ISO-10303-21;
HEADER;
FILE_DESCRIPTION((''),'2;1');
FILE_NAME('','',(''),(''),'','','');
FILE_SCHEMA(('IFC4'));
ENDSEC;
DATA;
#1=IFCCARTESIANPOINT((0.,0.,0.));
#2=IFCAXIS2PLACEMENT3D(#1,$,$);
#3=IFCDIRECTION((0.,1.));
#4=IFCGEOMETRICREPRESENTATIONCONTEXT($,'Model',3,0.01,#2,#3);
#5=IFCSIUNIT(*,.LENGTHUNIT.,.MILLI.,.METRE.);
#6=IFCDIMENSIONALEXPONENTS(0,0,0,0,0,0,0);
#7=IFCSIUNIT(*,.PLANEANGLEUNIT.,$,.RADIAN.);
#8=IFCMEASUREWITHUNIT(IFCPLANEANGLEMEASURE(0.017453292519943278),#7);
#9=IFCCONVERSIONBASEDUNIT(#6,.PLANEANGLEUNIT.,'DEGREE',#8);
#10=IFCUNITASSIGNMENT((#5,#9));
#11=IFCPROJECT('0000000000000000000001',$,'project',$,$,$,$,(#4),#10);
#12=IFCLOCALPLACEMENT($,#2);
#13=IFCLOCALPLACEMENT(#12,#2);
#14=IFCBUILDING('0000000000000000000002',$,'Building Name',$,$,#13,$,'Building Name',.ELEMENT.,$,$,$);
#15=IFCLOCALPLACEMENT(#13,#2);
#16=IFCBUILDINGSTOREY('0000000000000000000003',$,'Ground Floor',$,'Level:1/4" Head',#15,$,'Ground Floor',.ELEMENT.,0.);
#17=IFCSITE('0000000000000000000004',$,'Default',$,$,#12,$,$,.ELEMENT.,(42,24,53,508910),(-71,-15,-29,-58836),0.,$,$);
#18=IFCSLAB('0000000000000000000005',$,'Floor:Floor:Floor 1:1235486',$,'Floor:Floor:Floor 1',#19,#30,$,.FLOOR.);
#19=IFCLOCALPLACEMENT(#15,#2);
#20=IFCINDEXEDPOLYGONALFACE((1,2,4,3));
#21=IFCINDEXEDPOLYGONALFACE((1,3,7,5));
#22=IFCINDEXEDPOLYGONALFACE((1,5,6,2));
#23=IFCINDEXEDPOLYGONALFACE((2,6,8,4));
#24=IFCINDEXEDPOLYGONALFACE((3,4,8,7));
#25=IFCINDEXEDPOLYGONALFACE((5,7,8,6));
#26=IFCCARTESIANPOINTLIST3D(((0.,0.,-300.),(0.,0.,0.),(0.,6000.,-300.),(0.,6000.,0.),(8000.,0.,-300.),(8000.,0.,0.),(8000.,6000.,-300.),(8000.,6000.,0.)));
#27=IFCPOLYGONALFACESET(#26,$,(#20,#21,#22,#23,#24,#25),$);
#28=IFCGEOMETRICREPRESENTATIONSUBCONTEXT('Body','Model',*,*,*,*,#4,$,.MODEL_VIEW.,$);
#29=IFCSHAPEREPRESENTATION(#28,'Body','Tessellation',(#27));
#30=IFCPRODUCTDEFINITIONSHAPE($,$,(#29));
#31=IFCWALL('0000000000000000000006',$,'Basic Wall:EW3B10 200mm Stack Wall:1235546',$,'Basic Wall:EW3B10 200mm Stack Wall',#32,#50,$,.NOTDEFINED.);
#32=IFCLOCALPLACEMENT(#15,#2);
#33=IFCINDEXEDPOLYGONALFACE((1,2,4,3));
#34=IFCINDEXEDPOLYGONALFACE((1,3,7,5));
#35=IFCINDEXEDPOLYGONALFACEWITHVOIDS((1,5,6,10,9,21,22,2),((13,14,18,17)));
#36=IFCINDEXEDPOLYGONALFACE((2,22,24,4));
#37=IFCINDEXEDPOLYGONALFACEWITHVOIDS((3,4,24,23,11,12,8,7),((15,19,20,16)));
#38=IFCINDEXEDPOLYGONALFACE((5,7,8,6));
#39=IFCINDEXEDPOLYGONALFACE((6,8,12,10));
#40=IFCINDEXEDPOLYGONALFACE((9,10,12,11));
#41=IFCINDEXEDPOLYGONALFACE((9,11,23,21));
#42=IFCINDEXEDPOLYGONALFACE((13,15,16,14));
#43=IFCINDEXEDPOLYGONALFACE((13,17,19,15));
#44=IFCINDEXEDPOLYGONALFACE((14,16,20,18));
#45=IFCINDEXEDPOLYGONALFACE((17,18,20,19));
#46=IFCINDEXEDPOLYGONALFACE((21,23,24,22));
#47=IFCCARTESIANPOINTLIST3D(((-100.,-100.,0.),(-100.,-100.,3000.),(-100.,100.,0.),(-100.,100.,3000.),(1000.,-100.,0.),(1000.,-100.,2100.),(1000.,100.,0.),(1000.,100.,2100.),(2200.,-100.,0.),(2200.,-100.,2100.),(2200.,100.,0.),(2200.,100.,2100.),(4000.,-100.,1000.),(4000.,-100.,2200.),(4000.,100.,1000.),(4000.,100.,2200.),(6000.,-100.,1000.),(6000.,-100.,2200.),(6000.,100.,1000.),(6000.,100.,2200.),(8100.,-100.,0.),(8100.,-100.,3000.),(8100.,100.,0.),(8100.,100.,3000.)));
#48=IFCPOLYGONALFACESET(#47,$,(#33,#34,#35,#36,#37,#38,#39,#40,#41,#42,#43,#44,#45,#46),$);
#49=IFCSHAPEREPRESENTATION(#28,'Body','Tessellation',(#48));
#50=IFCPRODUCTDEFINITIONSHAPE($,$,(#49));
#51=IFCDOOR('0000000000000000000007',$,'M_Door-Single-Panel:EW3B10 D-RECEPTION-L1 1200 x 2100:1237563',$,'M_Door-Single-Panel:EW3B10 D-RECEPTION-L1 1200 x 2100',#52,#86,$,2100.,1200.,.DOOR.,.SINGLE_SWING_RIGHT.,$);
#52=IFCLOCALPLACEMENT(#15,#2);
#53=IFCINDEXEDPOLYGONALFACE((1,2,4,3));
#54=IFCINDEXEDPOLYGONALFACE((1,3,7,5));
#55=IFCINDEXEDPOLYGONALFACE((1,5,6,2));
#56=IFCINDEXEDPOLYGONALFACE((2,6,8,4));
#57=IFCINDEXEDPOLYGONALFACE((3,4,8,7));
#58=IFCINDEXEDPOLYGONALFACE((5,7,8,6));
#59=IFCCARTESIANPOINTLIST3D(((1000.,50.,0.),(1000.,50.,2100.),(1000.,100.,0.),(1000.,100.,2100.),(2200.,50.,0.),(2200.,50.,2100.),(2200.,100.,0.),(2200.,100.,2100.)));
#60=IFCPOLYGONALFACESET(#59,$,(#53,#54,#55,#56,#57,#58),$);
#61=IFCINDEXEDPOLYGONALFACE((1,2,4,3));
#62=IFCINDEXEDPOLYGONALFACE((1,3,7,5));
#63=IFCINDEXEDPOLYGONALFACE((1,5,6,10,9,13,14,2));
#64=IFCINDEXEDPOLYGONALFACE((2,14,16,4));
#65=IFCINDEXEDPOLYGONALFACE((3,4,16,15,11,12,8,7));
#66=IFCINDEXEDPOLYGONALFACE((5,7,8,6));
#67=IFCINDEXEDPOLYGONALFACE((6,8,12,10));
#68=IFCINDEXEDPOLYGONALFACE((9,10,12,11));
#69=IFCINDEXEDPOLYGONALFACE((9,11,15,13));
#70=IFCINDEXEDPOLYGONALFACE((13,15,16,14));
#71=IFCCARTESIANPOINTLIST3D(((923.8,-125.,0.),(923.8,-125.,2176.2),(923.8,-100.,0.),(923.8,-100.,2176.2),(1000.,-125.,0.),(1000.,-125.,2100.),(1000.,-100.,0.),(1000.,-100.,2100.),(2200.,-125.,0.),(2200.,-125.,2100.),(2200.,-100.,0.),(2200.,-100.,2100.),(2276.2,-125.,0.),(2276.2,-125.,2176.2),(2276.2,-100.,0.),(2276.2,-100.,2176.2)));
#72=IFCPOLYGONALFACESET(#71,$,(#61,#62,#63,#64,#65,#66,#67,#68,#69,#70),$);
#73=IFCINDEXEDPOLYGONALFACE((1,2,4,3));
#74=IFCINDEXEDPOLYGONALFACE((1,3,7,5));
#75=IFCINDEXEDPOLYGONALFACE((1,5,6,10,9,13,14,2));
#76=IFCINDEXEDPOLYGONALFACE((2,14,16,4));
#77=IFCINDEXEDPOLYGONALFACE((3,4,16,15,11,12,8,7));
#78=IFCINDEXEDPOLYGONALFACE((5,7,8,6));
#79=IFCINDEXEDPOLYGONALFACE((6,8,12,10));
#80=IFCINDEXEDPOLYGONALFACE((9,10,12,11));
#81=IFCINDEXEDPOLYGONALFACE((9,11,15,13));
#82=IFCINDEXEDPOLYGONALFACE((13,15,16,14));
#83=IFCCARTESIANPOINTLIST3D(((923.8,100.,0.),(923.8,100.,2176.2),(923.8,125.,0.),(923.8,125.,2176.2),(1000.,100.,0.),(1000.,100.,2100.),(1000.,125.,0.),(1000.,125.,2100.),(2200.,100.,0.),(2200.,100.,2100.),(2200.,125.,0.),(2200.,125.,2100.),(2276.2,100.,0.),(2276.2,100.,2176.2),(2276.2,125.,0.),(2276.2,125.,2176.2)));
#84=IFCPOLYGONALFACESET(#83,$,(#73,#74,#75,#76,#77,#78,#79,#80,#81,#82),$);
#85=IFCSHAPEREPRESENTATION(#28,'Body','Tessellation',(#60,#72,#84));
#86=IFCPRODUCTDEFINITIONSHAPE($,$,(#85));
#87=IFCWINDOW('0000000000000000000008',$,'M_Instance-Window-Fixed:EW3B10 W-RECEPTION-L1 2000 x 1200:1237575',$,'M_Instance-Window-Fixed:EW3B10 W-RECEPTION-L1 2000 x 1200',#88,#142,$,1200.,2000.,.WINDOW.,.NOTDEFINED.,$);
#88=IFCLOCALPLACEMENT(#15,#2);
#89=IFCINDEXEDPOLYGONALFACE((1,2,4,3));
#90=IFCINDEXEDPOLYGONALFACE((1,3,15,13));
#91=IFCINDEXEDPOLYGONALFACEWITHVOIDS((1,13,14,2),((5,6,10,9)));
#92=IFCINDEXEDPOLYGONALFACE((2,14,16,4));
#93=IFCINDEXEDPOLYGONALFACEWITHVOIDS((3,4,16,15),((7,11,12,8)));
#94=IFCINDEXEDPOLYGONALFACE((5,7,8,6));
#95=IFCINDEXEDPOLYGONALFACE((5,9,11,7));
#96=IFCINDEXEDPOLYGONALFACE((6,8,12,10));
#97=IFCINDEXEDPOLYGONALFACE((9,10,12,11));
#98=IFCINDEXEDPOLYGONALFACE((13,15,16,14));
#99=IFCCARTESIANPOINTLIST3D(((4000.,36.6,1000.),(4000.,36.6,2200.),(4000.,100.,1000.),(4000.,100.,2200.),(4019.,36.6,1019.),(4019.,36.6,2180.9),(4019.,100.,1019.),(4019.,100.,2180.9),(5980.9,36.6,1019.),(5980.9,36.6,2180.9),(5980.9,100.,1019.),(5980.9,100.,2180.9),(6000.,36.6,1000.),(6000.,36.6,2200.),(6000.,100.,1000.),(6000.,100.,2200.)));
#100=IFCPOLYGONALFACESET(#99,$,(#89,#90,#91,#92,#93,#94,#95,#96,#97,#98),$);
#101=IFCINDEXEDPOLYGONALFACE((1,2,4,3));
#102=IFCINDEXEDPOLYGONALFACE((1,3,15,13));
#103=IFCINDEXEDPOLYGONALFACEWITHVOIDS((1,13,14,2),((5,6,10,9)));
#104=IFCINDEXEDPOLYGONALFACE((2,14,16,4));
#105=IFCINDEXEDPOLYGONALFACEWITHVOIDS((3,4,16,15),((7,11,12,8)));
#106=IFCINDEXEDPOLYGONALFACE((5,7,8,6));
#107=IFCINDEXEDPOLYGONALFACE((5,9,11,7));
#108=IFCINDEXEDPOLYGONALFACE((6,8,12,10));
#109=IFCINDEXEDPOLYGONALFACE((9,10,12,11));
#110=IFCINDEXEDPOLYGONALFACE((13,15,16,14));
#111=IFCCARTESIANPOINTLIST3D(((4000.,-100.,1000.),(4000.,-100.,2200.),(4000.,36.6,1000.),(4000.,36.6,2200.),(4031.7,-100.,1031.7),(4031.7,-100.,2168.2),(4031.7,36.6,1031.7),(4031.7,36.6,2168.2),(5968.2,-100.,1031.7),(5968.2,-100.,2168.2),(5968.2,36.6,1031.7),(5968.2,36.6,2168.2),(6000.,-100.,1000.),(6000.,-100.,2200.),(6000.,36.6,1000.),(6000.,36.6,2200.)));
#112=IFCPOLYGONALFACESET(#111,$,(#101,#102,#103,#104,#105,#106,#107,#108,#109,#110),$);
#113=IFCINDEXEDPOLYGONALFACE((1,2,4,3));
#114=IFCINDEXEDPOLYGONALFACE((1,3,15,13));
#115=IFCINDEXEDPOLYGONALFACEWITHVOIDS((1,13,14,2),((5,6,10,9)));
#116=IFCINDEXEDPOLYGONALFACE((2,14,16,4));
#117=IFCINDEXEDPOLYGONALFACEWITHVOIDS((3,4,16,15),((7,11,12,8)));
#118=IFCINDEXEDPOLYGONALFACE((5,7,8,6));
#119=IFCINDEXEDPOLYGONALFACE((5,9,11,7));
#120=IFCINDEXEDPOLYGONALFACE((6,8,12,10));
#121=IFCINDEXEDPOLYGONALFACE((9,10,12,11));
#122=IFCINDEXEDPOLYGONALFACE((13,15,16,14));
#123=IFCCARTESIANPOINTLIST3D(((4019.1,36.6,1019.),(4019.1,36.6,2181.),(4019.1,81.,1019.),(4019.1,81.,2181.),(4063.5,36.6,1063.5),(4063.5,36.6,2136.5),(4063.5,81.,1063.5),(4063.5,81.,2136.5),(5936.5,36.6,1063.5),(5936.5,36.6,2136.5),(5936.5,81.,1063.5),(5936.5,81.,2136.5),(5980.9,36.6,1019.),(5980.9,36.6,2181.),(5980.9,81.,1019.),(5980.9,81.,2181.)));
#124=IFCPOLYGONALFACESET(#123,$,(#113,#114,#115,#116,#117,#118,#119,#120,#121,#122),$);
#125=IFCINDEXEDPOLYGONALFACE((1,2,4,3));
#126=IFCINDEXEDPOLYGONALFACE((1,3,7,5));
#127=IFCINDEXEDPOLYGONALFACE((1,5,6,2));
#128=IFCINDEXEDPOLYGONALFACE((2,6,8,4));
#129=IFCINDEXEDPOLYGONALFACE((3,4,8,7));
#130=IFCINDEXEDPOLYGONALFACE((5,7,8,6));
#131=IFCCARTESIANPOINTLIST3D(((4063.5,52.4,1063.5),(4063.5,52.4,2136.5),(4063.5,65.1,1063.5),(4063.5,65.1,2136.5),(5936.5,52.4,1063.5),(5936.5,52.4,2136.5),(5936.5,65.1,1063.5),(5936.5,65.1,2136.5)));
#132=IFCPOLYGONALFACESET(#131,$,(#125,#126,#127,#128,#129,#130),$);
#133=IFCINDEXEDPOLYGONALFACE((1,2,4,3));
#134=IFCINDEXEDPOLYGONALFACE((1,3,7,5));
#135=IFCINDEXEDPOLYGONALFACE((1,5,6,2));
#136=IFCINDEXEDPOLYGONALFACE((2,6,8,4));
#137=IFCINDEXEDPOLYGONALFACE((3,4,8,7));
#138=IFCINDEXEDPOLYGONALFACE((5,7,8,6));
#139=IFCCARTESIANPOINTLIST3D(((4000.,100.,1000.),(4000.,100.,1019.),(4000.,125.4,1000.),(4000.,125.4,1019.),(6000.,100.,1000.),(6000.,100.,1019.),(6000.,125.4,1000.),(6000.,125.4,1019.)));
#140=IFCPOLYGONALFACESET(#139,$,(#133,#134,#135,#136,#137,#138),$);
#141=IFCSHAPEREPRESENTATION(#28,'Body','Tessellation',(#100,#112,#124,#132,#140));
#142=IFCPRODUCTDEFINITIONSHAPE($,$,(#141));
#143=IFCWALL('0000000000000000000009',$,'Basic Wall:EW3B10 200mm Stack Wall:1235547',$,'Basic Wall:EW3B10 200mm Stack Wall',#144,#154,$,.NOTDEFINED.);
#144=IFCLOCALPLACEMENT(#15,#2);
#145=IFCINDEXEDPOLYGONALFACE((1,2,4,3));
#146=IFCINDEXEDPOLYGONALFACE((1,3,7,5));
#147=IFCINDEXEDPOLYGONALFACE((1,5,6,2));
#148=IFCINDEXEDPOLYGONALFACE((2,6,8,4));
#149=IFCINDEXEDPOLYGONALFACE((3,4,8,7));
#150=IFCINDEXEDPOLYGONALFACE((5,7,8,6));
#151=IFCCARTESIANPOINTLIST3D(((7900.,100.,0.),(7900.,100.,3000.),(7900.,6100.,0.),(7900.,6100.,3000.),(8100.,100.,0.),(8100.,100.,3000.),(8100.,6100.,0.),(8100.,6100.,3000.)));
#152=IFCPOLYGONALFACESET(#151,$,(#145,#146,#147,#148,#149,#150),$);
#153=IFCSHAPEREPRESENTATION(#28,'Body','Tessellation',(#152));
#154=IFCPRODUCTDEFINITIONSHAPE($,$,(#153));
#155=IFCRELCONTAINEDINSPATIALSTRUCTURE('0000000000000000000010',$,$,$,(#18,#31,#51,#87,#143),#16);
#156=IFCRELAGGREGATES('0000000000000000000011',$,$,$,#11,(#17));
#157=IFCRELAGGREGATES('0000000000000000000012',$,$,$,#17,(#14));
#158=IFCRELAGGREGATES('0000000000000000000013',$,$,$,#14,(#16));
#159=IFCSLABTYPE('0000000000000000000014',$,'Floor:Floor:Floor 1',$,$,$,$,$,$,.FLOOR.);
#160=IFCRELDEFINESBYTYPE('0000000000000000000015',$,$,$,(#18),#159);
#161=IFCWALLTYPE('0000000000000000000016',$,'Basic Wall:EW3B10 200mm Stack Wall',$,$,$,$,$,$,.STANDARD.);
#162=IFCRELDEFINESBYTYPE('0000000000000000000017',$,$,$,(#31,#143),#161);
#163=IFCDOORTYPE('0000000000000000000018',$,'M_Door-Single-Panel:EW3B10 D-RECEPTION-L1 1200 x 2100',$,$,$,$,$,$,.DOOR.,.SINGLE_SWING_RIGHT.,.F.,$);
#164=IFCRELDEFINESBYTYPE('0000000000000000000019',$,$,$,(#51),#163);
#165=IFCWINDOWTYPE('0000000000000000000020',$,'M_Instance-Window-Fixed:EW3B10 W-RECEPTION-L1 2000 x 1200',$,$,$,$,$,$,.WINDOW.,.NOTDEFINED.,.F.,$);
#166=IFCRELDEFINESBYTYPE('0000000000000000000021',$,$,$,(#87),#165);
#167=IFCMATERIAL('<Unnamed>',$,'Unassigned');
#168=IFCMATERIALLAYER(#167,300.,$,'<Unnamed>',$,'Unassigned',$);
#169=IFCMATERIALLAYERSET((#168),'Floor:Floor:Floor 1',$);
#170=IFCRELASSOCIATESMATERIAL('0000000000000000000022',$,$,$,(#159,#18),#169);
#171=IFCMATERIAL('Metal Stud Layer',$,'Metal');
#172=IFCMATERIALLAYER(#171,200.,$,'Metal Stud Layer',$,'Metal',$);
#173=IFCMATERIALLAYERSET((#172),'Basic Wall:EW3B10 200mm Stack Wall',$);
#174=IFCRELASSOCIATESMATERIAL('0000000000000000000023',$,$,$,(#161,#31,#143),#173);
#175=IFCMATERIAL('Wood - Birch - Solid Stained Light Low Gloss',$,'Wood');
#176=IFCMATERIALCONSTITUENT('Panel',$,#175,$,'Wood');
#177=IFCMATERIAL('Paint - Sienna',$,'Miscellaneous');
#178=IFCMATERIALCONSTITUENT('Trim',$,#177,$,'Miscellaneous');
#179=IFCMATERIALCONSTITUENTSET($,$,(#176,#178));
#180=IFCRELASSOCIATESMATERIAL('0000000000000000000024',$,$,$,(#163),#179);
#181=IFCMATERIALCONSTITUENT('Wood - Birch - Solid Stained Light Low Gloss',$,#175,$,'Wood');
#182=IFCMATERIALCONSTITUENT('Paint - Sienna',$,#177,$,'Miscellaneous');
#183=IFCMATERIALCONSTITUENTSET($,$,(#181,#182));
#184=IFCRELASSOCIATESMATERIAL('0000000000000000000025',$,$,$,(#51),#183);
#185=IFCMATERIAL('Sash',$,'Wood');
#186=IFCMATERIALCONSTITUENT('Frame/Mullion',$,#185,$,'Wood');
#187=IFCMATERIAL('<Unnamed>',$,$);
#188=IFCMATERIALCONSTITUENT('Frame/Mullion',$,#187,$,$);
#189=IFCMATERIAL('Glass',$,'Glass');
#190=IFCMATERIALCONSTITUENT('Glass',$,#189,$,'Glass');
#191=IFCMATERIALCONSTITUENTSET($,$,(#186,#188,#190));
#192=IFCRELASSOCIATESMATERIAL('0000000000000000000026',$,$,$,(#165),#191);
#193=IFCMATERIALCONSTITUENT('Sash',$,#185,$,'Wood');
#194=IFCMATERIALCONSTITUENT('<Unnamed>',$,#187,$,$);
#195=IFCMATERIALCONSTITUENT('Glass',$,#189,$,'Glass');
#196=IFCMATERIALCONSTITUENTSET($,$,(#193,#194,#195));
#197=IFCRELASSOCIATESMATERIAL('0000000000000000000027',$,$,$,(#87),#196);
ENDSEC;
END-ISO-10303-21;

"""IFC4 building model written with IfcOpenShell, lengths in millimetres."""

from ifc_helpers import new_model, entity, si_unit, converted_unit, direction, frame, frame_2d, origin, origin_2d_with_axis, place, context, subcontext, project, spatial, polyline, rectangle, outline, extrude, source, transform, mapped, material, layer, layer_set, layer_usage, constituent, constituent_set, type_object, type_shapes, element, fill, save


model = new_model("IFC4")

# Units and contexts
model_context = context("Model", 3, precision=0.01, world=origin(), true_north=direction((0.0, 1.0)))
body_context = subcontext(model_context, "Body", "Model", "MODEL_VIEW")
ifc_project = project(units=[si_unit("LENGTHUNIT", "METRE", prefix="MILLI"), converted_unit("PLANEANGLEUNIT", "DEGREE", entity("IfcPlaneAngleMeasure", 0.017453292519943278), si_unit("PLANEANGLEUNIT", "RADIAN"), dimensions=[0, 0, 0, 0, 0, 0, 0])], contexts=[model_context])

# Site, building, storey
site_placement = place(None, origin())
site = spatial("IfcSite", under=ifc_project, at=site_placement, Name="Default", CompositionType="ELEMENT", RefLatitude=(42, 24, 53, 508910), RefLongitude=(-71, -15, -29, -58836), RefElevation=0.0)
building_placement = place(site_placement, origin())
building = spatial("IfcBuilding", under=site, at=building_placement, Name="Building Name", LongName="Building Name", CompositionType="ELEMENT")
storey_placement = place(building_placement, origin())
storey = spatial("IfcBuildingStorey", under=building, at=storey_placement, Name="Ground Floor", ObjectType="Level:1/4\" Head", LongName="Ground Floor", CompositionType="ELEMENT", Elevation=0.0)

# Slab
ifc_material_1 = material(Name="<Unnamed>", Category="Unassigned")
ifc_layer_1 = layer(ifc_material_1, 300.0, Name="<Unnamed>", Category="Unassigned")
ifc_layer_set_1 = layer_set([ifc_layer_1], Name="Floor:Floor:Floor 1")
ifc_layer_usage_1 = layer_usage(ifc_layer_set_1, "AXIS3", "POSITIVE", 0.0)
slab_type = type_object("IfcSlabType", Name="Floor:Floor:Floor 1", PredefinedType="FLOOR", material=ifc_layer_set_1)
slab_placement = place(storey_placement, origin())
element("IfcSlab", 1, at=slab_placement, inside=storey, type_object=slab_type, material=ifc_layer_usage_1, Name="Floor:Floor:Floor 1:1235486", ObjectType="Floor:Floor:Floor 1", PredefinedType="FLOOR", context=body_context, shape_type="SweptSolid", body=[
    extrude(rectangle(XDim=6000.0, YDim=8000.0, at=origin_2d_with_axis()), frame((4000.0, 3000.0, 0.0), z_axis=(0.0, 0.0, -1.0), x_axis=(0.0, 1.0, 0.0)), (0.0, 0.0, 1.0), 300.0),
])

# Wall, openings, door, window
ifc_material_2 = material(Name="Metal Stud Layer", Category="Metal")
ifc_layer_2 = layer(ifc_material_2, 200.0, Name="Metal Stud Layer", Category="Metal")
ifc_layer_set_2 = layer_set([ifc_layer_2], Name="Basic Wall:EW3B10 200mm Stack Wall")
ifc_layer_usage_2 = layer_usage(ifc_layer_set_2, "AXIS2", "NEGATIVE", 100.0)
wall_type = type_object("IfcWallType", Name="Basic Wall:EW3B10 200mm Stack Wall", PredefinedType="STANDARD", material=ifc_layer_set_2)
wall_1_placement = place(storey_placement, frame((-100.0, 0.0, 0.0)))
wall_1 = element("IfcWall", 2, at=wall_1_placement, inside=storey, type_object=wall_type, material=ifc_layer_usage_2, Name="Basic Wall:EW3B10 200mm Stack Wall:1235546", ObjectType="Basic Wall:EW3B10 200mm Stack Wall", PredefinedType="NOTDEFINED", context=body_context, shape_type="SweptSolid", body=[
    extrude(rectangle(XDim=8200.0, YDim=200.0, at=frame_2d((4100.0, 0.0), x_axis=(1.0, 0.0))), origin(), (0.0, 0.0, 1.0), 3000.0),
])
opening_1_placement = place(wall_1_placement, frame((1100.0, -100.0, 0.0)))
opening_1 = element("IfcOpeningElement", 3, at=opening_1_placement, cuts=wall_1, PredefinedType="OPENING", context=body_context, shape_type="SweptSolid", body=[
    extrude(rectangle(XDim=1200.0, YDim=2100.0, at=frame_2d((1050.0, 600.0), x_axis=(0.0, 1.0))), frame((0.0, 0.0, 0.0), z_axis=(0.0, 1.0, 0.0), x_axis=(0.0, 0.0, 1.0)), (0.0, 0.0, 1.0), 200.0),
])
opening_2_placement = place(wall_1_placement, frame((4100.0, -100.0, 1000.0)))
opening_2 = element("IfcOpeningElement", 4, at=opening_2_placement, cuts=wall_1, PredefinedType="OPENING", context=body_context, shape_type="SweptSolid", body=[
    extrude(rectangle(XDim=1200.0, YDim=2000.0, at=frame_2d((600.0, 1000.0), x_axis=(-1.0, 0.0))), frame((0.0, 0.0, 0.0), z_axis=(0.0, 1.0, 0.0), x_axis=(0.0, 0.0, 1.0)), (0.0, 0.0, 1.0), 200.0),
])
ifc_material_3 = material(Name="Wood - Birch - Solid Stained Light Low Gloss", Category="Wood")
ifc_constituent_1 = constituent(ifc_material_3, Name="Wood - Birch - Solid Stained Light Low Gloss", Category="Wood")
ifc_material_4 = material(Name="Paint - Sienna", Category="Miscellaneous")
ifc_constituent_2 = constituent(ifc_material_4, Name="Paint - Sienna", Category="Miscellaneous")
ifc_constituent_set_1 = constituent_set(constituents=[ifc_constituent_1, ifc_constituent_2])
ifc_constituent_3 = constituent(ifc_material_3, Name="Panel", Category="Wood")
ifc_constituent_4 = constituent(ifc_material_4, Name="Trim", Category="Miscellaneous")
ifc_constituent_set_2 = constituent_set(constituents=[ifc_constituent_3, ifc_constituent_4])
door_type = type_object("IfcDoorType", Name="M_Door-Single-Panel:EW3B10 D-RECEPTION-L1 1200 x 2100", OperationType="SINGLE_SWING_RIGHT", ParameterTakesPrecedence=False, PredefinedType="DOOR", material=ifc_constituent_set_2)
shared_shape_1 = source(origin(), body_context, "Body", "SweptSolid", [
    extrude(rectangle(XDim=50.0, YDim=1200.0, at=frame_2d((0.0, 0.0), x_axis=(1.0, 0.0))), frame((600.0, 175.0, 0.0), z_axis=(0.0, 0.0, 1.0), x_axis=(0.0, 1.0, 0.0)), (0.0, 0.0, 1.0), 2100.0),
    extrude(outline(polyline([(-1107.1, -676.2), (1069.0, -676.2), (1069.0, -600.0), (-1030.9, -600.0), (-1030.9, 600.0), (1069.0, 600.0), (1069.0, 676.2), (-1107.1, 676.2), (-1107.1, -676.2)])), frame((600.0, -25.0, 1069.0), z_axis=(0.0, 1.0, 0.0), x_axis=(0.0, 0.0, -1.0)), (0.0, 0.0, 1.0), 25.0),
    extrude(outline(polyline([(-676.2, -1107.1), (676.2, -1107.1), (676.2, 1069.1), (600.0, 1069.1), (600.0, -1031.0), (-600.0, -1031.0), (-600.0, 1069.1), (-676.2, 1069.1), (-676.2, -1107.1)])), frame((600.0, 200.0, 1069.1), z_axis=(0.0, 1.0, 0.0), x_axis=(1.0, 0.0, 0.0)), (0.0, 0.0, 1.0), 25.0),
])
type_shapes(door_type, [shared_shape_1])
door_placement = place(opening_1_placement, origin())
door = element("IfcDoor", 5, at=door_placement, inside=storey, type_object=door_type, material=ifc_constituent_set_1, Name="M_Door-Single-Panel:EW3B10 D-RECEPTION-L1 1200 x 2100:1237563", ObjectType="M_Door-Single-Panel:EW3B10 D-RECEPTION-L1 1200 x 2100", OperationType="SINGLE_SWING_RIGHT", OverallHeight=2100.0, OverallWidth=1200.0, PredefinedType="DOOR", context=body_context, shape_type="MappedRepresentation", body=[
    mapped(shared_shape_1, transform((0.0, 0.0, 0.0), scale=1.0)),
])
fill(opening_1, door)
ifc_material_5 = material(Name="Sash", Category="Wood")
ifc_constituent_5 = constituent(ifc_material_5, Name="Sash", Category="Wood")
ifc_material_6 = material(Name="<Unnamed>")
ifc_constituent_6 = constituent(ifc_material_6, Name="<Unnamed>")
ifc_material_7 = material(Name="Glass", Category="Glass")
ifc_constituent_7 = constituent(ifc_material_7, Name="Glass", Category="Glass")
ifc_constituent_set_3 = constituent_set(constituents=[ifc_constituent_5, ifc_constituent_6, ifc_constituent_7])
ifc_constituent_8 = constituent(ifc_material_5, Name="Frame/Mullion", Category="Wood")
ifc_constituent_9 = constituent(ifc_material_6, Name="Frame/Mullion")
ifc_constituent_10 = constituent(ifc_material_7, Name="Glass", Category="Glass")
ifc_constituent_set_4 = constituent_set(constituents=[ifc_constituent_8, ifc_constituent_9, ifc_constituent_10])
window_type = type_object("IfcWindowType", Name="M_Instance-Window-Fixed:EW3B10 W-RECEPTION-L1 2000 x 1200", ParameterTakesPrecedence=False, PartitioningType="NOTDEFINED", PredefinedType="WINDOW", material=ifc_constituent_set_4)
shared_shape_2 = source(origin(), body_context, "Body", "SweptSolid", [
    extrude(outline(polyline([(-600.0, -1000.0), (600.0, -1000.0), (600.0, 1000.0), (-600.0, 1000.0), (-600.0, -1000.0)]), holes=[polyline([(-580.9, -980.9), (-580.9, 981.0), (581.0, 981.0), (581.0, -980.9), (-580.9, -980.9)])]), frame((1000.0, 136.6, 600.0), z_axis=(0.0, 1.0, 0.0), x_axis=(0.0, 0.0, -1.0)), (0.0, 0.0, 1.0), 63.5),
    extrude(outline(polyline([(-1000.0, -600.0), (1000.0, -600.0), (1000.0, 600.0), (-1000.0, 600.0), (-1000.0, -600.0)]), holes=[polyline([(-968.3, -568.2), (-968.3, 568.3), (968.2, 568.3), (968.2, -568.2), (-968.3, -568.2)])]), frame((1000.0, 0.0, 600.0), z_axis=(0.0, 1.0, 0.0), x_axis=(1.0, 0.0, 0.0)), (0.0, 0.0, 1.0), 136.6),
    extrude(outline(polyline([(-980.9, -581.0), (980.9, -581.0), (980.9, 581.0), (-980.9, 581.0), (-980.9, -581.0)]), holes=[polyline([(-936.5, -536.5), (-936.5, 536.5), (936.5, 536.5), (936.5, -536.5), (-936.5, -536.5)])]), frame((1000.0, 136.6, 600.0), z_axis=(0.0, 1.0, 0.0), x_axis=(1.0, 0.0, 0.0)), (0.0, 0.0, 1.0), 44.4),
    extrude(rectangle(XDim=12.7, YDim=1873.0, at=frame_2d((0.0, 0.0), x_axis=(1.0, 0.0))), frame((1000.0, 158.8, 63.5), z_axis=(0.0, 0.0, 1.0), x_axis=(0.0, 1.0, 0.0)), (0.0, 0.0, 1.0), 1073.0),
    extrude(rectangle(XDim=25.4, YDim=2000.0, at=frame_2d((0.0, 0.0), x_axis=(1.0, 0.0))), frame((1000.0, 212.7, 0.0), z_axis=(0.0, 0.0, 1.0), x_axis=(0.0, -1.0, 0.0)), (0.0, 0.0, 1.0), 19.0),
])
type_shapes(window_type, [shared_shape_2])
window_placement = place(opening_2_placement, origin())
window = element("IfcWindow", 6, at=window_placement, inside=storey, type_object=window_type, material=ifc_constituent_set_3, Name="M_Instance-Window-Fixed:EW3B10 W-RECEPTION-L1 2000 x 1200:1237575", ObjectType="M_Instance-Window-Fixed:EW3B10 W-RECEPTION-L1 2000 x 1200", OverallHeight=1200.0, OverallWidth=2000.0, PartitioningType="NOTDEFINED", PredefinedType="WINDOW", context=body_context, shape_type="MappedRepresentation", body=[
    mapped(shared_shape_2, transform((0.0, 0.0, 0.0), scale=1.0)),
])
fill(opening_2, window)

# Wall
ifc_layer_usage_3 = layer_usage(ifc_layer_set_2, "AXIS2", "NEGATIVE", 100.0)
wall_2_placement = place(storey_placement, frame((8000.0, 100.0, 0.0), z_axis=(0.0, 0.0, 1.0), x_axis=(0.0, 1.0, 0.0)))
element("IfcWall", 7, at=wall_2_placement, inside=storey, type_object=wall_type, material=ifc_layer_usage_3, Name="Basic Wall:EW3B10 200mm Stack Wall:1235547", ObjectType="Basic Wall:EW3B10 200mm Stack Wall", PredefinedType="NOTDEFINED", context=body_context, shape_type="SweptSolid", body=[
    extrude(rectangle(XDim=6000.0, YDim=200.0, at=frame_2d((3000.0, 0.0), x_axis=(-1.0, 0.0))), origin(), (0.0, 0.0, 1.0), 3000.0),
])

save(model, "model.ifc")
